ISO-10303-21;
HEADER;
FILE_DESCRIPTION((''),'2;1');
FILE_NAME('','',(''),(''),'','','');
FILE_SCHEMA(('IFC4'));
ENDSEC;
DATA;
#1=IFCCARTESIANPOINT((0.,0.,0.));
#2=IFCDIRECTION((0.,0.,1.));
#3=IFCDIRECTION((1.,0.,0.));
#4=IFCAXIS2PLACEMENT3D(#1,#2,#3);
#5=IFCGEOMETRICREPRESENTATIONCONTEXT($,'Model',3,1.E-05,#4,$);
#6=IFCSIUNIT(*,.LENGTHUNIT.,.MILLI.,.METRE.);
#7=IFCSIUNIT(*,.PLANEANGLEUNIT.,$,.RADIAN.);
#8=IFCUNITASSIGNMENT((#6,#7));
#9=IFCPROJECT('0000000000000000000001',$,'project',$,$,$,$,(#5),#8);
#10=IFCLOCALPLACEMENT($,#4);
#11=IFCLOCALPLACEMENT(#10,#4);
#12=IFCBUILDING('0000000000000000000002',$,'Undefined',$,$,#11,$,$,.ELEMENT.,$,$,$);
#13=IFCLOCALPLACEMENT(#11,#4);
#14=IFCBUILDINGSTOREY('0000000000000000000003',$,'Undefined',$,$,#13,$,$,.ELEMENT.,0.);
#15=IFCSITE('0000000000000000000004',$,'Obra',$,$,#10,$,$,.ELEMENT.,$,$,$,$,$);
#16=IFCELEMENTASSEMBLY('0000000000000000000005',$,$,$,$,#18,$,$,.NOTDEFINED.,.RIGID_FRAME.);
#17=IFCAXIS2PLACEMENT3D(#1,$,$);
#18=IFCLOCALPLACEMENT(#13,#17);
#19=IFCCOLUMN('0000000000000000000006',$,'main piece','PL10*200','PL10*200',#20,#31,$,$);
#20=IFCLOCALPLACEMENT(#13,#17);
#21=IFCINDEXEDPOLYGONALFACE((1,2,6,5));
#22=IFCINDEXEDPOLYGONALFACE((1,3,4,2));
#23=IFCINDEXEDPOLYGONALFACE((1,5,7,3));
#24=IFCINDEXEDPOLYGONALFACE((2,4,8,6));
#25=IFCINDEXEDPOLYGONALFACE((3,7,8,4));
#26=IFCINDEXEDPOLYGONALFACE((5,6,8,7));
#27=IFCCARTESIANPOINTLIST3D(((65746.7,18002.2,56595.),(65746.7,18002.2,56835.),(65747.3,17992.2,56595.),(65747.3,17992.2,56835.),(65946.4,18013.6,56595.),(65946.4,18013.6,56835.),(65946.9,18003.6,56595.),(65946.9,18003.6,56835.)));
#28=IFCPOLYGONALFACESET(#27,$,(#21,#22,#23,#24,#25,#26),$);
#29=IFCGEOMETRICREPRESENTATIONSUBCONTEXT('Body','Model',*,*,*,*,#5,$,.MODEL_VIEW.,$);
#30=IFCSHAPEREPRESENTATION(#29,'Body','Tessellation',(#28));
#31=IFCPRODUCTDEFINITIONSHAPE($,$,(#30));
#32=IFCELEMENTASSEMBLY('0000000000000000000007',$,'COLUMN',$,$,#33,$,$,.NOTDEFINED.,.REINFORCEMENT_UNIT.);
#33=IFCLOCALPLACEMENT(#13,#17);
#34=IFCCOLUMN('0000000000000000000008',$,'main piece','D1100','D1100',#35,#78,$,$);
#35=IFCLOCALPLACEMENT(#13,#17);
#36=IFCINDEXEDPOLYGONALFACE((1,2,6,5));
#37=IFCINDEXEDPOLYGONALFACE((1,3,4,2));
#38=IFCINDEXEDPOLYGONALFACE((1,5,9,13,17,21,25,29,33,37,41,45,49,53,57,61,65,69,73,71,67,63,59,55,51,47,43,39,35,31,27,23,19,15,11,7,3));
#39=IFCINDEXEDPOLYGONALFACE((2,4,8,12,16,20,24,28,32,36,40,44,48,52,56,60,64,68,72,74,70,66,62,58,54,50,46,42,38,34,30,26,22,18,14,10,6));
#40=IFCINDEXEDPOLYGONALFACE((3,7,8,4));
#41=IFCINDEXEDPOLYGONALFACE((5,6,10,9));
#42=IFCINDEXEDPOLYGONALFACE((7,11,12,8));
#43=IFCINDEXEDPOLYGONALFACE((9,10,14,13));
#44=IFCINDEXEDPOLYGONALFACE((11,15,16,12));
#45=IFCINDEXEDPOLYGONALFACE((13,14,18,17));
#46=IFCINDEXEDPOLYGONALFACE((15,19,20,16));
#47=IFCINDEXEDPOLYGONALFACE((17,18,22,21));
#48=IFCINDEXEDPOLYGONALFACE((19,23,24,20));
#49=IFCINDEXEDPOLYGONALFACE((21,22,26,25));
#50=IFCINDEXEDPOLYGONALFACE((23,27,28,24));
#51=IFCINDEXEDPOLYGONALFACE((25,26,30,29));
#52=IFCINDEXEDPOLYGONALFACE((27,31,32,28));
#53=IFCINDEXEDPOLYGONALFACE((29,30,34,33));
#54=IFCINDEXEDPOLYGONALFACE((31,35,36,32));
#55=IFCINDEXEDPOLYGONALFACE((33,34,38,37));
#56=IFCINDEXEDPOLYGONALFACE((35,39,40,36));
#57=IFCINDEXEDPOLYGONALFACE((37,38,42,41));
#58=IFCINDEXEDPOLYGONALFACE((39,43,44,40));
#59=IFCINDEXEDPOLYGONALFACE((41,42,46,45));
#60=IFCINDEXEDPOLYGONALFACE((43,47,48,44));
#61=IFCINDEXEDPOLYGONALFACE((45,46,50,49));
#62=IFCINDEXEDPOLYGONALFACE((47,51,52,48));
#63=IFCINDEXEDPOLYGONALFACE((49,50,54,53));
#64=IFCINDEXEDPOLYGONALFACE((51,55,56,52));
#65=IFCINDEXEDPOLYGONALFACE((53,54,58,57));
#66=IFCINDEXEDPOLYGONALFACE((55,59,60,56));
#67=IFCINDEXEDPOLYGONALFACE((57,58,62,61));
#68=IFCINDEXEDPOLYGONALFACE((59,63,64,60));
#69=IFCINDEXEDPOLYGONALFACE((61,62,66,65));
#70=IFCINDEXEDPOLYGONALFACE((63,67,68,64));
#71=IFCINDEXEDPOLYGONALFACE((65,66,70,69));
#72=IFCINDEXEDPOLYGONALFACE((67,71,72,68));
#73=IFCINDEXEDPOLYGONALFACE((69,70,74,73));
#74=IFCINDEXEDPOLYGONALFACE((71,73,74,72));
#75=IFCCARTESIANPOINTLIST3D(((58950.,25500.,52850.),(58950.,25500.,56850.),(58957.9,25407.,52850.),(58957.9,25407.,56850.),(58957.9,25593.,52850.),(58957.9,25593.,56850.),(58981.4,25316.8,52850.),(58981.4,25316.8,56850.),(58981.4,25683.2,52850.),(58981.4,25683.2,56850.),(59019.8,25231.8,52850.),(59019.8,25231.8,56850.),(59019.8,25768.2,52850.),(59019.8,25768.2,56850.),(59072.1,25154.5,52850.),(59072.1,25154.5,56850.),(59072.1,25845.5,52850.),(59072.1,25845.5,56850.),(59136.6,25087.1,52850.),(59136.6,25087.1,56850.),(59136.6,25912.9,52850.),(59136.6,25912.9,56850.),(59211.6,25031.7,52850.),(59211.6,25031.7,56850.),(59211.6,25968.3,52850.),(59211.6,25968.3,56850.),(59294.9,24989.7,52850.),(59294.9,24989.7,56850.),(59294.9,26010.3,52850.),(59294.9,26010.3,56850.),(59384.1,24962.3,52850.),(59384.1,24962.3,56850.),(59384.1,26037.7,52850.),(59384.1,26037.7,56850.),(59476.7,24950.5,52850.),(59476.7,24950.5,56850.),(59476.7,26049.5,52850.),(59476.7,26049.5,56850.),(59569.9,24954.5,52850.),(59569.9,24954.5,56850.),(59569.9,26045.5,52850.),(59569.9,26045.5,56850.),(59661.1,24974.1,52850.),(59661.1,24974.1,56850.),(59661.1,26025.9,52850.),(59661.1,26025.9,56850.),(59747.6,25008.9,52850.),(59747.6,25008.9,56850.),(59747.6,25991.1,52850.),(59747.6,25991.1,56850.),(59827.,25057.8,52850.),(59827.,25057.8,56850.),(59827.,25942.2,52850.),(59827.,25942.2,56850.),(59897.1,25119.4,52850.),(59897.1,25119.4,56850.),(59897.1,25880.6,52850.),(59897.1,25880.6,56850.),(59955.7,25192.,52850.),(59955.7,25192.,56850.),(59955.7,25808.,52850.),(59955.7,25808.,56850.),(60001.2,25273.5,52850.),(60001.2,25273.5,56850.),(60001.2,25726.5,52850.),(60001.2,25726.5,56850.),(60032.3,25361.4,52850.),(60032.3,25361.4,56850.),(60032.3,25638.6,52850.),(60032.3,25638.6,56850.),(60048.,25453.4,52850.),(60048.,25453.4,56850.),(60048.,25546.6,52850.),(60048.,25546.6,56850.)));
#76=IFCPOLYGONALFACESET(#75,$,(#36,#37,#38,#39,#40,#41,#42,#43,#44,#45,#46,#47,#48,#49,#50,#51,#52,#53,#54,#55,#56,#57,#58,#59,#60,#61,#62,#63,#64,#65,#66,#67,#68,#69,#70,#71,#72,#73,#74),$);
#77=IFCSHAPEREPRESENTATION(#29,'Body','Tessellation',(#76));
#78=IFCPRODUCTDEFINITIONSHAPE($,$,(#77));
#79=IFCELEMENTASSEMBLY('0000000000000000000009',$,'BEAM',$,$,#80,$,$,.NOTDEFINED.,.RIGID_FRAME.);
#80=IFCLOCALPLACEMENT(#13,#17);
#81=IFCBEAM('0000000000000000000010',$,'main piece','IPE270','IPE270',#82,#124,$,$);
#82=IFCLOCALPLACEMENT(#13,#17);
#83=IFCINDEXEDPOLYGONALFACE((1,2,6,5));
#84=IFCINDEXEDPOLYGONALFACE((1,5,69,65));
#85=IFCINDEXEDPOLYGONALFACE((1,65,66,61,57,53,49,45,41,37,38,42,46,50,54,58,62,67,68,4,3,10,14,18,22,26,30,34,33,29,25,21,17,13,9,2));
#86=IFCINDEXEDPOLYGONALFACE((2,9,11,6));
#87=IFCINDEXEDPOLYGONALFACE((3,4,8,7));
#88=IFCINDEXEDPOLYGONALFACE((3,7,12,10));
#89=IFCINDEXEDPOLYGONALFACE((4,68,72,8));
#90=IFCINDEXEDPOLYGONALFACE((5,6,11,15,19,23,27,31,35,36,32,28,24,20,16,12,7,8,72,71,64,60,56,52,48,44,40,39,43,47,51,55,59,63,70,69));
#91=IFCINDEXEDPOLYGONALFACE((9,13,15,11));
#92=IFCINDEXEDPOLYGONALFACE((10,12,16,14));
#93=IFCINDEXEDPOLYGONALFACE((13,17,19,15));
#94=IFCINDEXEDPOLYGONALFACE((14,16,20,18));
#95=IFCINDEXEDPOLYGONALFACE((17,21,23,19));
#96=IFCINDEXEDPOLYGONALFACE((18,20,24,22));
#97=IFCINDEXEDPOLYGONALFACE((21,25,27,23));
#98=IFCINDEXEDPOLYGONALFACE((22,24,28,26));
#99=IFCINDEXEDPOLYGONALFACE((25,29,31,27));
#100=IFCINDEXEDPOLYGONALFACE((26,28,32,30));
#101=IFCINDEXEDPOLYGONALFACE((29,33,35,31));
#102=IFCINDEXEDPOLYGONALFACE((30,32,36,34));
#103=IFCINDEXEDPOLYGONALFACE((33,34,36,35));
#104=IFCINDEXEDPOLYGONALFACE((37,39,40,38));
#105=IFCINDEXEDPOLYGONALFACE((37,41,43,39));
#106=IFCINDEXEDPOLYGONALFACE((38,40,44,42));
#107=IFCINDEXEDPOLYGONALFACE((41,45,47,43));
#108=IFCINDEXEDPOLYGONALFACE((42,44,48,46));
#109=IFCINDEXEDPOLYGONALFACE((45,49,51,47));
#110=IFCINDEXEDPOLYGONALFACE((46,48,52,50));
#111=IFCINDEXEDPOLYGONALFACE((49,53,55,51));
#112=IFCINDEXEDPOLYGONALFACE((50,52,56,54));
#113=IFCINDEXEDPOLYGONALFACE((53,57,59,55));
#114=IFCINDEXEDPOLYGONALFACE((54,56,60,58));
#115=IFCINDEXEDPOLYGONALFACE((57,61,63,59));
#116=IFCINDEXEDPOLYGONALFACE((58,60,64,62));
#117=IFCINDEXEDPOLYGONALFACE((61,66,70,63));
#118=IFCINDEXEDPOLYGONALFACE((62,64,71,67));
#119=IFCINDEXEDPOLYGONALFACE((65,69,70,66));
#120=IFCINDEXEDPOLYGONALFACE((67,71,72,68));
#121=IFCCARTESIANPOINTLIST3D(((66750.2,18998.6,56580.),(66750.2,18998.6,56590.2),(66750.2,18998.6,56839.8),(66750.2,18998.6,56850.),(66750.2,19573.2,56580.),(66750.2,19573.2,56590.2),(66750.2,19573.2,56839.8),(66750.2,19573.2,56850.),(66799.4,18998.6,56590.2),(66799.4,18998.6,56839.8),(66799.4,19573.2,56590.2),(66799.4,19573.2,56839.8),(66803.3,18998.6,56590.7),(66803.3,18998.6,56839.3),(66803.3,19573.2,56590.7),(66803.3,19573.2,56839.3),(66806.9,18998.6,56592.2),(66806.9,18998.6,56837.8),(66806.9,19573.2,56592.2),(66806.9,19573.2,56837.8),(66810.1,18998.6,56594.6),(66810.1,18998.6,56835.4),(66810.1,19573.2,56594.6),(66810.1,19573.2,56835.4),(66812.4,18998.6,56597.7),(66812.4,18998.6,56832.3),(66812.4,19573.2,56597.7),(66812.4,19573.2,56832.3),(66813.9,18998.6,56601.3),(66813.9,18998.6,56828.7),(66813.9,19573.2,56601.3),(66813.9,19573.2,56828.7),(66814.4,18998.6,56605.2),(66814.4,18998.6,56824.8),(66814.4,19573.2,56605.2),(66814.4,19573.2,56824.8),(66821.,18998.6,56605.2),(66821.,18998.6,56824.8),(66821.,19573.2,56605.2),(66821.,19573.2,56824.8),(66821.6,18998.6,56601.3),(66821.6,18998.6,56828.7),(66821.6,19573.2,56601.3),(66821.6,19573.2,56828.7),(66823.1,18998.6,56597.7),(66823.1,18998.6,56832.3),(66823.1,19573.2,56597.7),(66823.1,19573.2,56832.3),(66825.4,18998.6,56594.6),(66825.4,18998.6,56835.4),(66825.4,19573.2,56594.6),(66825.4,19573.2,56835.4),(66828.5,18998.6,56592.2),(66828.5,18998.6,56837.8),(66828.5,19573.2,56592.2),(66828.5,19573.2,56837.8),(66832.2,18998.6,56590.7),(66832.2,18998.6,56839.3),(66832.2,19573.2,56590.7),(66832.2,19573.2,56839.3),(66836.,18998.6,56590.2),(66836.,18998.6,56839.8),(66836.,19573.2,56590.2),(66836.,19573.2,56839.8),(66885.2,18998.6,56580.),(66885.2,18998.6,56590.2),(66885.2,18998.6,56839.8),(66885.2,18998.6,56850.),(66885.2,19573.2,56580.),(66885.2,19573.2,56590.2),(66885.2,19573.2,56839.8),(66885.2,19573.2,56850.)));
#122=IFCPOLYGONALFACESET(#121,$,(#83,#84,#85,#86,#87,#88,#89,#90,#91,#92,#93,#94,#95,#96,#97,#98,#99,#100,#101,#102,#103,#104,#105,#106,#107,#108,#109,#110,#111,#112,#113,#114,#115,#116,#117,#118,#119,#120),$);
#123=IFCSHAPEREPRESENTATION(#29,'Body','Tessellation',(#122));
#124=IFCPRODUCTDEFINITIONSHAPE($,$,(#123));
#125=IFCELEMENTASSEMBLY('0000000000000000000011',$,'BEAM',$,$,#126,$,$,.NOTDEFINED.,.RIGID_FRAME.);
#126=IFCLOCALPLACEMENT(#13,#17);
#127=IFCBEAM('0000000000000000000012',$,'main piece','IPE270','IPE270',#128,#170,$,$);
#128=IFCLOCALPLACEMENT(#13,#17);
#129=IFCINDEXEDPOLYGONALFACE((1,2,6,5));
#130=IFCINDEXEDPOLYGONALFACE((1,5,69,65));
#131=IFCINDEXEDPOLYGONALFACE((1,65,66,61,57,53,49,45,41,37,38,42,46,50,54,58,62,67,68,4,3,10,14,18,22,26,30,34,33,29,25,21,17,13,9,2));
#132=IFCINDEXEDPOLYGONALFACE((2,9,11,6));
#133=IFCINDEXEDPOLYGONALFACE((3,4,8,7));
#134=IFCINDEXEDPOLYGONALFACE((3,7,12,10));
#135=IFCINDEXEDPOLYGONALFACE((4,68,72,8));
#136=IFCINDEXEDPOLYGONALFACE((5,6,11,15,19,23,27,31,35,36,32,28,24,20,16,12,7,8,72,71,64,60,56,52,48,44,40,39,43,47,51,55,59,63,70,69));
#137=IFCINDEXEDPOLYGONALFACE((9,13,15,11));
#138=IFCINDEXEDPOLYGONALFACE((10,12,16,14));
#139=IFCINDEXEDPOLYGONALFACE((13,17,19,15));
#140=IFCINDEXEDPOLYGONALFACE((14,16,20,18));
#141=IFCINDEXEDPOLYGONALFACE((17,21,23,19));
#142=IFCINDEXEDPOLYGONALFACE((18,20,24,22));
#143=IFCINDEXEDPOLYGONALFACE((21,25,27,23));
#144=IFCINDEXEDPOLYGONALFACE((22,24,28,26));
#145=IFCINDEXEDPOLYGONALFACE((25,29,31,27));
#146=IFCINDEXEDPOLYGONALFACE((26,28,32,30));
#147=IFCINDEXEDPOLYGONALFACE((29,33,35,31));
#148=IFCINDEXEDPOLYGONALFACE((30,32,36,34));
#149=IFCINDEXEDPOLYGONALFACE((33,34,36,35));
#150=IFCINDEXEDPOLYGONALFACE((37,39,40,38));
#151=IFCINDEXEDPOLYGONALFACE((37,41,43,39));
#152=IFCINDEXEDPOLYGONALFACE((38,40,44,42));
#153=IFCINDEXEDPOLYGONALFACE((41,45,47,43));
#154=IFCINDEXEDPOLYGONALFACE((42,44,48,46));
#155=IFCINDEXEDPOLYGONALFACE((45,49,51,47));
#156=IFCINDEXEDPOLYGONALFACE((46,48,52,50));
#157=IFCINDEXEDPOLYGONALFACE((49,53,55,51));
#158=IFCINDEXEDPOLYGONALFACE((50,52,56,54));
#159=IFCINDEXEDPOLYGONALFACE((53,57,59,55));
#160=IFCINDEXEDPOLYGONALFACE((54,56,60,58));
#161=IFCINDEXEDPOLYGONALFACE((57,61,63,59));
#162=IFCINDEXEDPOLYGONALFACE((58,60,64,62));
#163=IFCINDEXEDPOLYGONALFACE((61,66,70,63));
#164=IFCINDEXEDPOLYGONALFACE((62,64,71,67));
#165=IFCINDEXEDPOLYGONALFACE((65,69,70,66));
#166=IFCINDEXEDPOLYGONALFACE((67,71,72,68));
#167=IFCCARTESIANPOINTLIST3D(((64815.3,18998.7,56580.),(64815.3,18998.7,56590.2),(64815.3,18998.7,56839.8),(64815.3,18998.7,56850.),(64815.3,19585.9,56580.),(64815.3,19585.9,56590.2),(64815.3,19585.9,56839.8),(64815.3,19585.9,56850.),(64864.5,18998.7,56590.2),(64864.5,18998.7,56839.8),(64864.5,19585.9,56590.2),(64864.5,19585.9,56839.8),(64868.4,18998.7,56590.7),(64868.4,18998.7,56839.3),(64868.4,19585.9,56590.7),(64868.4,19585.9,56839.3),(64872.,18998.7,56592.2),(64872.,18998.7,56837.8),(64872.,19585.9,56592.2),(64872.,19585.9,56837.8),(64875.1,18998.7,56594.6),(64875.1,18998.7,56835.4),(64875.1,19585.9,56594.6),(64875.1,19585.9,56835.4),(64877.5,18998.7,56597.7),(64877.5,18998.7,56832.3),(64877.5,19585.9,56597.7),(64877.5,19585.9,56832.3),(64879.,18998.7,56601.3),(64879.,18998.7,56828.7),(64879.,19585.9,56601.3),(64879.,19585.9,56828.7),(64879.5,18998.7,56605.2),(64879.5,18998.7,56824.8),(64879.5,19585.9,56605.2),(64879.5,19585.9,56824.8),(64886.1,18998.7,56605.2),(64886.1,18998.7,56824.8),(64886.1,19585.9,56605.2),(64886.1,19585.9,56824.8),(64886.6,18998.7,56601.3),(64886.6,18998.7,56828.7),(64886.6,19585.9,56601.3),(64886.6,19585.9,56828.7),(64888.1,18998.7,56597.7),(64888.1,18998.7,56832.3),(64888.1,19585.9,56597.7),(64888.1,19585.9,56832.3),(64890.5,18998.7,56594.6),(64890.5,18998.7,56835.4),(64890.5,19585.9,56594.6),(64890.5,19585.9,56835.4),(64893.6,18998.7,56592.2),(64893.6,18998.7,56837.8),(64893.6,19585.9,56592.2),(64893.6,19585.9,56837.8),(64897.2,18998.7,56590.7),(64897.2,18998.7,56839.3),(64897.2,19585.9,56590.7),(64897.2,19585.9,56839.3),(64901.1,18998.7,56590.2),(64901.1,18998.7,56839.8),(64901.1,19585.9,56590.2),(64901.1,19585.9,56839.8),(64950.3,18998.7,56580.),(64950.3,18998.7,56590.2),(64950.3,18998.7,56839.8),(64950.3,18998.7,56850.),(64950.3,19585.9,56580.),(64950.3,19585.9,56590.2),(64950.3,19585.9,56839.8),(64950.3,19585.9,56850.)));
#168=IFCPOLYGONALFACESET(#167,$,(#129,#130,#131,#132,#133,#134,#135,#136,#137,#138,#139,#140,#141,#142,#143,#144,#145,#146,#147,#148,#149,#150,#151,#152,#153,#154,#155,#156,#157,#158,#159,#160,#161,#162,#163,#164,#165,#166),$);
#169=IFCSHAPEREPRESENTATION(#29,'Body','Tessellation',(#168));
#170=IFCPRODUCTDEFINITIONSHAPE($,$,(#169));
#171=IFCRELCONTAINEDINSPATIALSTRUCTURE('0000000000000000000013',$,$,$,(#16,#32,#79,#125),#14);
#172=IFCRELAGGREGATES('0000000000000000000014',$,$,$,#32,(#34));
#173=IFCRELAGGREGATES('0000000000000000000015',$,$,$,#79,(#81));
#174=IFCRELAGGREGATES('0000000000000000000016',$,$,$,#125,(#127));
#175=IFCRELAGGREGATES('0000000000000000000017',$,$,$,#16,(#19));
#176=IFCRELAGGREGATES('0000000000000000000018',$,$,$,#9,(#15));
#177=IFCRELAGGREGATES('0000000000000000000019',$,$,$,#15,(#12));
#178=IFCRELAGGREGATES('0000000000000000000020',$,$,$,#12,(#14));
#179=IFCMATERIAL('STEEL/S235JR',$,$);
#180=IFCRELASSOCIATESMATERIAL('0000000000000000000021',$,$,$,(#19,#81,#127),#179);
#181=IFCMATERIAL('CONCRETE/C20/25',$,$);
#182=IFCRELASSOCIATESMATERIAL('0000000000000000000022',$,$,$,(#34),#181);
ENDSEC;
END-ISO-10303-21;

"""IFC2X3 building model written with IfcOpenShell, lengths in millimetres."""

from ifc_helpers import new_model, si_unit, frame, origin_with_axes, origin_2d_with_axis, place, context, subcontext, project, spatial, rectangle, circle, i_section, extrude, material, element, aggregate, save


model = new_model("IFC2X3")

# Units and contexts
model_context = context("Model", 3, precision=1e-05, world=origin_with_axes())
body_context = subcontext(model_context, "Body", "Model", "MODEL_VIEW")
ifc_project = project(units=[si_unit("LENGTHUNIT", "METRE", prefix="MILLI"), si_unit("PLANEANGLEUNIT", "RADIAN")], contexts=[model_context])

# Site, building, storey
site_placement = place(None, origin_with_axes())
site = spatial("IfcSite", under=ifc_project, at=site_placement, Name="Obra", CompositionType="ELEMENT")
building_placement = place(site_placement, origin_with_axes())
building = spatial("IfcBuilding", under=site, at=building_placement, Name="Undefined", CompositionType="ELEMENT")
storey_placement = place(building_placement, origin_with_axes())
storey = spatial("IfcBuildingStorey", under=building, at=storey_placement, Name="Undefined", CompositionType="ELEMENT", Elevation=0.0)

# Element assemblies, columns
assembly_1_placement = place(storey_placement, origin_with_axes())
assembly_1 = element("IfcElementAssembly", 1, at=assembly_1_placement, inside=storey, AssemblyPlace="NOTDEFINED", PredefinedType="RIGID_FRAME")
ifc_material_1 = material(Name="STEEL/S235JR")
column_1_placement = place(assembly_1_placement, frame((65846.8, 18002.9, 56595.0), z_axis=(0.0, 0.0, 1.0), x_axis=(0.998368, 0.057107, 0.0)))
column_1 = element("IfcColumn", 2, at=column_1_placement, material=ifc_material_1, Name="main piece", Description="PL10*200", ObjectType="PL10*200", context=body_context, shape_type="SweptSolid", body=[
    extrude(rectangle(XDim=10.0, YDim=200.0, at=origin_2d_with_axis()), frame((0.0, 0.0, 240.0), z_axis=(0.0, 0.0, -1.0), x_axis=(0.0, 1.0, 0.0)), (0.0, 0.0, 1.0), 240.0),
])
assembly_2_placement = place(storey_placement, origin_with_axes())
assembly_2 = element("IfcElementAssembly", 3, at=assembly_2_placement, inside=storey, Name="COLUMN", AssemblyPlace="NOTDEFINED", PredefinedType="REINFORCEMENT_UNIT")
ifc_material_2 = material(Name="CONCRETE/C20/25")
column_2_placement = place(assembly_2_placement, frame((59500.0, 25500.0, 52850.0), z_axis=(0.0, 0.0, 1.0), x_axis=(0.0, 1.0, 0.0)))
column_2 = element("IfcColumn", 4, at=column_2_placement, material=ifc_material_2, Name="main piece", Description="D1100", ObjectType="D1100", context=body_context, shape_type="SweptSolid", body=[
    extrude(circle(Radius=550.0, at=origin_2d_with_axis()), frame((0.0, 0.0, 4000.0), z_axis=(0.0, 0.0, -1.0), x_axis=(0.0, 1.0, 0.0)), (0.0, 0.0, 1.0), 4000.0),
])
aggregate(assembly_2, [column_2])

# Element assemblies, beams
assembly_3_placement = place(storey_placement, origin_with_axes())
assembly_3 = element("IfcElementAssembly", 5, at=assembly_3_placement, inside=storey, Name="BEAM", AssemblyPlace="NOTDEFINED", PredefinedType="RIGID_FRAME")
beam_1_placement = place(assembly_3_placement, frame((66817.7, 18998.6, 56715.0), z_axis=(0.0, 0.0, 1.0), x_axis=(0.0, 1.0, 0.0)))
beam_1 = element("IfcBeam", 6, at=beam_1_placement, material=ifc_material_1, Name="main piece", Description="IPE270", ObjectType="IPE270", context=body_context, shape_type="SweptSolid", body=[
    extrude(i_section(OverallWidth=135.0, OverallDepth=270.0, WebThickness=6.6, FlangeThickness=10.2, FilletRadius=15.0, at=origin_2d_with_axis()), frame((574.6, 0.0, 0.0), z_axis=(-1.0, 0.0, 0.0), x_axis=(0.0, -1.0, 0.0)), (0.0, 0.0, 1.0), 574.6),
])
aggregate(assembly_3, [beam_1])
assembly_4_placement = place(storey_placement, origin_with_axes())
assembly_4 = element("IfcElementAssembly", 7, at=assembly_4_placement, inside=storey, Name="BEAM", AssemblyPlace="NOTDEFINED", PredefinedType="RIGID_FRAME")
beam_2_placement = place(assembly_4_placement, frame((64882.8, 18998.7, 56715.0), z_axis=(0.0, 0.0, 1.0), x_axis=(-0.000002, 1.0, 0.0)))
beam_2 = element("IfcBeam", 8, at=beam_2_placement, material=ifc_material_1, Name="main piece", Description="IPE270", ObjectType="IPE270", context=body_context, shape_type="SweptSolid", body=[
    extrude(i_section(OverallWidth=135.0, OverallDepth=270.0, WebThickness=6.6, FlangeThickness=10.2, FilletRadius=15.0, at=origin_2d_with_axis()), frame((587.2, 0.0, 0.0), z_axis=(-1.0, 0.0, 0.0), x_axis=(0.0, -1.0, 0.0)), (0.0, 0.0, 1.0), 587.2),
])
aggregate(assembly_4, [beam_2])

aggregate(assembly_1, [column_1])

save(model, "model.ifc")
